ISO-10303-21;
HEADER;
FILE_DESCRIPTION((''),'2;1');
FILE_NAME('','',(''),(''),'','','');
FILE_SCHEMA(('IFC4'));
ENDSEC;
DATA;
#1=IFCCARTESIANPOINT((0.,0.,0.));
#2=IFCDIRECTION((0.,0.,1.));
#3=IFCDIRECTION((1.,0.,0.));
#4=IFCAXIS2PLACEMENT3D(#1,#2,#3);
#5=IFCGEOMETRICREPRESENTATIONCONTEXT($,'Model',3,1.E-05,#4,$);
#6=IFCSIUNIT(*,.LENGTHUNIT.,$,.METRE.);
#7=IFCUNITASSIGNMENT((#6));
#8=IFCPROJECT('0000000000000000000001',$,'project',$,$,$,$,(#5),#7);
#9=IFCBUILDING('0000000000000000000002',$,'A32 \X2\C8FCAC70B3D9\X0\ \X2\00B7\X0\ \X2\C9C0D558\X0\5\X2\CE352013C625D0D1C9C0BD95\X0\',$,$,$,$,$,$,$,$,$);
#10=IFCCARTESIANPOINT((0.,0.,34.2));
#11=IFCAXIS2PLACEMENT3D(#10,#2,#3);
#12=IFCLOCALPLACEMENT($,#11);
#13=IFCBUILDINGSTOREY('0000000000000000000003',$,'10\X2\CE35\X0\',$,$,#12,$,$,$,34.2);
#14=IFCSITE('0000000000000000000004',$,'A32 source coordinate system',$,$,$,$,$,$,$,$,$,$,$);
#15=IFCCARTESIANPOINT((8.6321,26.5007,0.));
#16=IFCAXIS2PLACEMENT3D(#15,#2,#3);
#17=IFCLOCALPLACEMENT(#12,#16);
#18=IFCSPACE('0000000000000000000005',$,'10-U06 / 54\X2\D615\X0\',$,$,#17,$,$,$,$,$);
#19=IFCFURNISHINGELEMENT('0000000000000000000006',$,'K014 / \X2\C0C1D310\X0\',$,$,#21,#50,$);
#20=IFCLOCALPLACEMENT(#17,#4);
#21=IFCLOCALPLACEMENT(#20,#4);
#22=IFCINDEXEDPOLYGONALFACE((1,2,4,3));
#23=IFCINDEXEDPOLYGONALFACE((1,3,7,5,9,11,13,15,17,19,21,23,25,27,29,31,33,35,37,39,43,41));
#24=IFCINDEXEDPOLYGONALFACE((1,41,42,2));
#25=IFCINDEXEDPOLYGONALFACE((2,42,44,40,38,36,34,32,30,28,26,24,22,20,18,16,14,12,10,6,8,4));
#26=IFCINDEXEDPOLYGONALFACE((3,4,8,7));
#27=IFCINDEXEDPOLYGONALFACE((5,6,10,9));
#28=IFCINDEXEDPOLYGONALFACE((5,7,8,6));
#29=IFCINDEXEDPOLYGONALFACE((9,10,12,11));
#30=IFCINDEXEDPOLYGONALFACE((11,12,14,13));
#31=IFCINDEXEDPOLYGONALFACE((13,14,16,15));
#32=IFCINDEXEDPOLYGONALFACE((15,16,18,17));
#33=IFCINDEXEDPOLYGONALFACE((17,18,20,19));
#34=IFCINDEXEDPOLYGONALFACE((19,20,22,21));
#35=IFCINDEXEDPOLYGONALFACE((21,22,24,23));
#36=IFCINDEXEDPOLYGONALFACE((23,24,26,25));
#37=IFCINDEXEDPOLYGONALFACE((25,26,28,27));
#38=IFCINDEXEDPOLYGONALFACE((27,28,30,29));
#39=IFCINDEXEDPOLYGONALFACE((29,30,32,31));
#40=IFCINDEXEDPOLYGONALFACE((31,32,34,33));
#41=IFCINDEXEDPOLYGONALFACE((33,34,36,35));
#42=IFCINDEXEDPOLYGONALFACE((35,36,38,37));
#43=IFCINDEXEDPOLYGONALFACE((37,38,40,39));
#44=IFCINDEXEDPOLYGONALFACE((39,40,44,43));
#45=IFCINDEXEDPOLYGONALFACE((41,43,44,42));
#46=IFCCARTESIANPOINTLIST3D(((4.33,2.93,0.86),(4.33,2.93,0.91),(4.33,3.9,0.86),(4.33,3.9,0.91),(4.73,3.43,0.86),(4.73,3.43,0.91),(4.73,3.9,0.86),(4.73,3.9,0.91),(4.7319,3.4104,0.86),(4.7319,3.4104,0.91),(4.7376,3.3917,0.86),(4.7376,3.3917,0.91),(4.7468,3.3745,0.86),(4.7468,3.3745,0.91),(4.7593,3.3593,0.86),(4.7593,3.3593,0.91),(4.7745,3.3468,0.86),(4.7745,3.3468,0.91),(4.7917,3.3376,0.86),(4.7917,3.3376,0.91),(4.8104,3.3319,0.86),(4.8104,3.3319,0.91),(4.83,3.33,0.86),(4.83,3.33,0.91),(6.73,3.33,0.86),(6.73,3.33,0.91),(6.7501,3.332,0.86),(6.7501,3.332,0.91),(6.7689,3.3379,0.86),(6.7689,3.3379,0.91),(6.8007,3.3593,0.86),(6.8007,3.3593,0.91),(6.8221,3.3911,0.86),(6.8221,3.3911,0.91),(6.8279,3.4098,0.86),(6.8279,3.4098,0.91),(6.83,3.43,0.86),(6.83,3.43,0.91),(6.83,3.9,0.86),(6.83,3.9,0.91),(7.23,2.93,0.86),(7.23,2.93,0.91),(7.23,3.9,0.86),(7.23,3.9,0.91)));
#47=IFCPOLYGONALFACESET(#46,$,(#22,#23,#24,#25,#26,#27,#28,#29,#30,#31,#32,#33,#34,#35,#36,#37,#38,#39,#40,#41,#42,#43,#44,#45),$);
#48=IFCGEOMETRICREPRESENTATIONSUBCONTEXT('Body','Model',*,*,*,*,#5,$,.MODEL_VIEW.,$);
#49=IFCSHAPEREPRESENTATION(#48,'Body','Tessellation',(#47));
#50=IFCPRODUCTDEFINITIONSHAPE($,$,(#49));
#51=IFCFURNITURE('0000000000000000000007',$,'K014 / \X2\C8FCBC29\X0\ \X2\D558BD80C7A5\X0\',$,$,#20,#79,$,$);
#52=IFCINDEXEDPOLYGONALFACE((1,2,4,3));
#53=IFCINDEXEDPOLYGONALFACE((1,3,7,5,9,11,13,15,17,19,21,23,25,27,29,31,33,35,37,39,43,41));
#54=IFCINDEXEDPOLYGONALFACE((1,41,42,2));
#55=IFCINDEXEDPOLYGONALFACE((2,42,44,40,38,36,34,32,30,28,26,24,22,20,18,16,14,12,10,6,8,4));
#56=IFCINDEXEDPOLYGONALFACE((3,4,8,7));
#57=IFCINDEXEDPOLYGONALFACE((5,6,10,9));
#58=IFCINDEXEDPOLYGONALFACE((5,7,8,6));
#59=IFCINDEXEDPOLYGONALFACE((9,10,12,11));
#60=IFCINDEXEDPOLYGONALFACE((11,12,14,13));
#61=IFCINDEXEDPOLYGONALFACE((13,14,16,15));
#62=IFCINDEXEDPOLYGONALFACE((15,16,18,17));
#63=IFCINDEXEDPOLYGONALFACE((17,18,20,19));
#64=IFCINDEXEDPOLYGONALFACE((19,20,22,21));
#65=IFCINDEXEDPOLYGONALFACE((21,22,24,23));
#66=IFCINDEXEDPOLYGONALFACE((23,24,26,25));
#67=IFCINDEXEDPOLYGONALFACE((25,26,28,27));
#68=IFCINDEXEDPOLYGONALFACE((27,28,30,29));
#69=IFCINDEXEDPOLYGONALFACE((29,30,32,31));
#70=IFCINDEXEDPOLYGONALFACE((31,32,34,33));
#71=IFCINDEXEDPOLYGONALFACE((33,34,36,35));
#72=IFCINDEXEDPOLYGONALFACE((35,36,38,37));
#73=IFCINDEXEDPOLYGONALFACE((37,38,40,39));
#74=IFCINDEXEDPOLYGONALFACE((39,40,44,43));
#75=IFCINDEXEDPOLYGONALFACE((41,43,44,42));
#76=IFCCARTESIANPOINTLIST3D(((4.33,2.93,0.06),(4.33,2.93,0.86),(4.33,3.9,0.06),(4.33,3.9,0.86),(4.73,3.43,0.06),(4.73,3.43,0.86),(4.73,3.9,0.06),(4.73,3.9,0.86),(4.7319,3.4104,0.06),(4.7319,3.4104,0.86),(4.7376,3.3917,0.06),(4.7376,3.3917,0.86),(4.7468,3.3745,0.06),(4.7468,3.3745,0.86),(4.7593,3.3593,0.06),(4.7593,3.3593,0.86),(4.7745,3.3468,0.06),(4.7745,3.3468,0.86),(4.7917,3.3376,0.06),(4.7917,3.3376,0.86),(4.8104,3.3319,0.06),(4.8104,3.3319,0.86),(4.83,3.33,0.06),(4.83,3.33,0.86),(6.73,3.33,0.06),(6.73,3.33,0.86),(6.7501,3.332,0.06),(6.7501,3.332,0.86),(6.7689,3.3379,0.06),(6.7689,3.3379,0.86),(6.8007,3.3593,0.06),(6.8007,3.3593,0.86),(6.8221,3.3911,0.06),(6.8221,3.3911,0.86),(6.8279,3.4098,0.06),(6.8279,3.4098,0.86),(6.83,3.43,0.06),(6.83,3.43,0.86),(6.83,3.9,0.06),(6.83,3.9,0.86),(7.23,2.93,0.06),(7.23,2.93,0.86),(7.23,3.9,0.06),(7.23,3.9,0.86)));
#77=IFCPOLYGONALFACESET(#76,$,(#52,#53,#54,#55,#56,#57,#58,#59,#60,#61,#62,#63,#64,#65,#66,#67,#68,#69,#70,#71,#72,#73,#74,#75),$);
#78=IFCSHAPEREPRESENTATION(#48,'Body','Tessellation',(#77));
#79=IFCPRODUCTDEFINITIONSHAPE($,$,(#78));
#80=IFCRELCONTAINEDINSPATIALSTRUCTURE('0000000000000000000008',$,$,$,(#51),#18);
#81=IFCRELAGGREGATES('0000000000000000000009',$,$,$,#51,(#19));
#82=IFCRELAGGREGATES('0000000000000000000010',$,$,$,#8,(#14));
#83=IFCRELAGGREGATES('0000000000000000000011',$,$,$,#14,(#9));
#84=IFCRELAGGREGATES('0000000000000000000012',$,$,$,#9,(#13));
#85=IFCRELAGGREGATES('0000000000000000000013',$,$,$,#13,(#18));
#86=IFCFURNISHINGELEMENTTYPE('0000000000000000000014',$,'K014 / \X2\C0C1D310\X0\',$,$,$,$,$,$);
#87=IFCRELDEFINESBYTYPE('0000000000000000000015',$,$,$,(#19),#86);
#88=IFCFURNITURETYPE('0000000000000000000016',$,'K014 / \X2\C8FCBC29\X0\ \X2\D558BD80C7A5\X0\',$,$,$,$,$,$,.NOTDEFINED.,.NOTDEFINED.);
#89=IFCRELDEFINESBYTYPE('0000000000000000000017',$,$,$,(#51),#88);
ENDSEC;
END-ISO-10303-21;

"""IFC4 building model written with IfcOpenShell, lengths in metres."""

from ifc_helpers import new_model, si_unit, frame, origin, origin_with_axes, place, context, subcontext, project, spatial, polyline, outline, extrude, source, transform, mapped, type_object, type_shapes, element, aggregate, save


model = new_model("IFC4")

# Units and contexts
model_context = context("Model", 3, precision=1e-05, world=origin_with_axes())
body_context = subcontext(model_context, "Body", "Model", "MODEL_VIEW")
ifc_project = project(units=[si_unit("LENGTHUNIT", "METRE")], contexts=[model_context])

# Site, building, storey, space
site = spatial("IfcSite", under=ifc_project, Name="A32 source coordinate system")
building = spatial("IfcBuilding", under=site, Name="A32 주거동 · 지하5층–옥탑지붕")
storey_placement = place(None, frame((0.0, 0.0, 34.2), z_axis=(0.0, 0.0, 1.0), x_axis=(1.0, 0.0, 0.0)))
storey = spatial("IfcBuildingStorey", under=building, at=storey_placement, Name="10층", Elevation=34.2)
space_placement = place(storey_placement, frame((8.6321, 26.5007, 0.0), z_axis=(0.0, 0.0, 1.0), x_axis=(1.0, 0.0, 0.0)))
space = spatial("IfcSpace", under=storey, at=space_placement, Name="10-U06 / 54형")

# Furnishing element
furnishing_element_type_1 = type_object("IfcFurnishingElementType", Name="K014 / 상판")
shared_shape_1 = source(origin(), body_context, "Body", "SweptSolid", [
    extrude(outline(polyline([(4.33, 2.93), (4.33, 3.9), (4.73, 3.9), (4.73, 3.43), (4.7319, 3.4104), (4.7376, 3.3917), (4.7468, 3.3745), (4.7593, 3.3593), (4.7745, 3.3468), (4.7917, 3.3376), (4.8104, 3.3319), (4.83, 3.33), (6.73, 3.33), (6.7501, 3.332), (6.7689, 3.3379), (6.8007, 3.3593), (6.8221, 3.3911), (6.8279, 3.4098), (6.83, 3.43), (6.83, 3.9), (7.23, 3.9), (7.23, 2.93), (4.33, 2.93)])), frame((0.0, 0.0, 0.86)), (0.0, 0.0, 1.0), 0.05),
])
type_shapes(furnishing_element_type_1, [shared_shape_1])
furniture_1_placement = place(space_placement, origin_with_axes())
furnishing_1_placement = place(furniture_1_placement, origin_with_axes())
furnishing_1 = element("IfcFurnishingElement", 1, at=furnishing_1_placement, type_object=furnishing_element_type_1, Name="K014 / 상판", context=body_context, shape_type="MappedRepresentation", body=[
    mapped(shared_shape_1, transform((0.0, 0.0, 0.0), scale=1.0)),
])

# Furniture
furniture_type_1 = type_object("IfcFurnitureType", Name="K014 / 주방 하부장", AssemblyPlace="NOTDEFINED", PredefinedType="NOTDEFINED")
shared_shape_2 = source(origin(), body_context, "Body", "SweptSolid", [
    extrude(outline(polyline([(7.23, 2.93), (4.33, 2.93), (4.33, 3.9), (4.73, 3.9), (4.73, 3.43), (4.7319, 3.4104), (4.7376, 3.3917), (4.7468, 3.3745), (4.7593, 3.3593), (4.7745, 3.3468), (4.7917, 3.3376), (4.8104, 3.3319), (4.83, 3.33), (6.73, 3.33), (6.7501, 3.332), (6.7689, 3.3379), (6.8007, 3.3593), (6.8221, 3.3911), (6.8279, 3.4098), (6.83, 3.43), (6.83, 3.9), (7.23, 3.9), (7.23, 2.93)])), frame((0.0, 0.0, 0.06)), (0.0, 0.0, 1.0), 0.8),
])
type_shapes(furniture_type_1, [shared_shape_2])
furniture_1 = element("IfcFurniture", 2, at=furniture_1_placement, inside=space, type_object=furniture_type_1, Name="K014 / 주방 하부장", context=body_context, shape_type="MappedRepresentation", body=[
    mapped(shared_shape_2, transform((0.0, 0.0, 0.0), scale=1.0)),
])
aggregate(furniture_1, [furnishing_1])

save(model, "model.ifc")
